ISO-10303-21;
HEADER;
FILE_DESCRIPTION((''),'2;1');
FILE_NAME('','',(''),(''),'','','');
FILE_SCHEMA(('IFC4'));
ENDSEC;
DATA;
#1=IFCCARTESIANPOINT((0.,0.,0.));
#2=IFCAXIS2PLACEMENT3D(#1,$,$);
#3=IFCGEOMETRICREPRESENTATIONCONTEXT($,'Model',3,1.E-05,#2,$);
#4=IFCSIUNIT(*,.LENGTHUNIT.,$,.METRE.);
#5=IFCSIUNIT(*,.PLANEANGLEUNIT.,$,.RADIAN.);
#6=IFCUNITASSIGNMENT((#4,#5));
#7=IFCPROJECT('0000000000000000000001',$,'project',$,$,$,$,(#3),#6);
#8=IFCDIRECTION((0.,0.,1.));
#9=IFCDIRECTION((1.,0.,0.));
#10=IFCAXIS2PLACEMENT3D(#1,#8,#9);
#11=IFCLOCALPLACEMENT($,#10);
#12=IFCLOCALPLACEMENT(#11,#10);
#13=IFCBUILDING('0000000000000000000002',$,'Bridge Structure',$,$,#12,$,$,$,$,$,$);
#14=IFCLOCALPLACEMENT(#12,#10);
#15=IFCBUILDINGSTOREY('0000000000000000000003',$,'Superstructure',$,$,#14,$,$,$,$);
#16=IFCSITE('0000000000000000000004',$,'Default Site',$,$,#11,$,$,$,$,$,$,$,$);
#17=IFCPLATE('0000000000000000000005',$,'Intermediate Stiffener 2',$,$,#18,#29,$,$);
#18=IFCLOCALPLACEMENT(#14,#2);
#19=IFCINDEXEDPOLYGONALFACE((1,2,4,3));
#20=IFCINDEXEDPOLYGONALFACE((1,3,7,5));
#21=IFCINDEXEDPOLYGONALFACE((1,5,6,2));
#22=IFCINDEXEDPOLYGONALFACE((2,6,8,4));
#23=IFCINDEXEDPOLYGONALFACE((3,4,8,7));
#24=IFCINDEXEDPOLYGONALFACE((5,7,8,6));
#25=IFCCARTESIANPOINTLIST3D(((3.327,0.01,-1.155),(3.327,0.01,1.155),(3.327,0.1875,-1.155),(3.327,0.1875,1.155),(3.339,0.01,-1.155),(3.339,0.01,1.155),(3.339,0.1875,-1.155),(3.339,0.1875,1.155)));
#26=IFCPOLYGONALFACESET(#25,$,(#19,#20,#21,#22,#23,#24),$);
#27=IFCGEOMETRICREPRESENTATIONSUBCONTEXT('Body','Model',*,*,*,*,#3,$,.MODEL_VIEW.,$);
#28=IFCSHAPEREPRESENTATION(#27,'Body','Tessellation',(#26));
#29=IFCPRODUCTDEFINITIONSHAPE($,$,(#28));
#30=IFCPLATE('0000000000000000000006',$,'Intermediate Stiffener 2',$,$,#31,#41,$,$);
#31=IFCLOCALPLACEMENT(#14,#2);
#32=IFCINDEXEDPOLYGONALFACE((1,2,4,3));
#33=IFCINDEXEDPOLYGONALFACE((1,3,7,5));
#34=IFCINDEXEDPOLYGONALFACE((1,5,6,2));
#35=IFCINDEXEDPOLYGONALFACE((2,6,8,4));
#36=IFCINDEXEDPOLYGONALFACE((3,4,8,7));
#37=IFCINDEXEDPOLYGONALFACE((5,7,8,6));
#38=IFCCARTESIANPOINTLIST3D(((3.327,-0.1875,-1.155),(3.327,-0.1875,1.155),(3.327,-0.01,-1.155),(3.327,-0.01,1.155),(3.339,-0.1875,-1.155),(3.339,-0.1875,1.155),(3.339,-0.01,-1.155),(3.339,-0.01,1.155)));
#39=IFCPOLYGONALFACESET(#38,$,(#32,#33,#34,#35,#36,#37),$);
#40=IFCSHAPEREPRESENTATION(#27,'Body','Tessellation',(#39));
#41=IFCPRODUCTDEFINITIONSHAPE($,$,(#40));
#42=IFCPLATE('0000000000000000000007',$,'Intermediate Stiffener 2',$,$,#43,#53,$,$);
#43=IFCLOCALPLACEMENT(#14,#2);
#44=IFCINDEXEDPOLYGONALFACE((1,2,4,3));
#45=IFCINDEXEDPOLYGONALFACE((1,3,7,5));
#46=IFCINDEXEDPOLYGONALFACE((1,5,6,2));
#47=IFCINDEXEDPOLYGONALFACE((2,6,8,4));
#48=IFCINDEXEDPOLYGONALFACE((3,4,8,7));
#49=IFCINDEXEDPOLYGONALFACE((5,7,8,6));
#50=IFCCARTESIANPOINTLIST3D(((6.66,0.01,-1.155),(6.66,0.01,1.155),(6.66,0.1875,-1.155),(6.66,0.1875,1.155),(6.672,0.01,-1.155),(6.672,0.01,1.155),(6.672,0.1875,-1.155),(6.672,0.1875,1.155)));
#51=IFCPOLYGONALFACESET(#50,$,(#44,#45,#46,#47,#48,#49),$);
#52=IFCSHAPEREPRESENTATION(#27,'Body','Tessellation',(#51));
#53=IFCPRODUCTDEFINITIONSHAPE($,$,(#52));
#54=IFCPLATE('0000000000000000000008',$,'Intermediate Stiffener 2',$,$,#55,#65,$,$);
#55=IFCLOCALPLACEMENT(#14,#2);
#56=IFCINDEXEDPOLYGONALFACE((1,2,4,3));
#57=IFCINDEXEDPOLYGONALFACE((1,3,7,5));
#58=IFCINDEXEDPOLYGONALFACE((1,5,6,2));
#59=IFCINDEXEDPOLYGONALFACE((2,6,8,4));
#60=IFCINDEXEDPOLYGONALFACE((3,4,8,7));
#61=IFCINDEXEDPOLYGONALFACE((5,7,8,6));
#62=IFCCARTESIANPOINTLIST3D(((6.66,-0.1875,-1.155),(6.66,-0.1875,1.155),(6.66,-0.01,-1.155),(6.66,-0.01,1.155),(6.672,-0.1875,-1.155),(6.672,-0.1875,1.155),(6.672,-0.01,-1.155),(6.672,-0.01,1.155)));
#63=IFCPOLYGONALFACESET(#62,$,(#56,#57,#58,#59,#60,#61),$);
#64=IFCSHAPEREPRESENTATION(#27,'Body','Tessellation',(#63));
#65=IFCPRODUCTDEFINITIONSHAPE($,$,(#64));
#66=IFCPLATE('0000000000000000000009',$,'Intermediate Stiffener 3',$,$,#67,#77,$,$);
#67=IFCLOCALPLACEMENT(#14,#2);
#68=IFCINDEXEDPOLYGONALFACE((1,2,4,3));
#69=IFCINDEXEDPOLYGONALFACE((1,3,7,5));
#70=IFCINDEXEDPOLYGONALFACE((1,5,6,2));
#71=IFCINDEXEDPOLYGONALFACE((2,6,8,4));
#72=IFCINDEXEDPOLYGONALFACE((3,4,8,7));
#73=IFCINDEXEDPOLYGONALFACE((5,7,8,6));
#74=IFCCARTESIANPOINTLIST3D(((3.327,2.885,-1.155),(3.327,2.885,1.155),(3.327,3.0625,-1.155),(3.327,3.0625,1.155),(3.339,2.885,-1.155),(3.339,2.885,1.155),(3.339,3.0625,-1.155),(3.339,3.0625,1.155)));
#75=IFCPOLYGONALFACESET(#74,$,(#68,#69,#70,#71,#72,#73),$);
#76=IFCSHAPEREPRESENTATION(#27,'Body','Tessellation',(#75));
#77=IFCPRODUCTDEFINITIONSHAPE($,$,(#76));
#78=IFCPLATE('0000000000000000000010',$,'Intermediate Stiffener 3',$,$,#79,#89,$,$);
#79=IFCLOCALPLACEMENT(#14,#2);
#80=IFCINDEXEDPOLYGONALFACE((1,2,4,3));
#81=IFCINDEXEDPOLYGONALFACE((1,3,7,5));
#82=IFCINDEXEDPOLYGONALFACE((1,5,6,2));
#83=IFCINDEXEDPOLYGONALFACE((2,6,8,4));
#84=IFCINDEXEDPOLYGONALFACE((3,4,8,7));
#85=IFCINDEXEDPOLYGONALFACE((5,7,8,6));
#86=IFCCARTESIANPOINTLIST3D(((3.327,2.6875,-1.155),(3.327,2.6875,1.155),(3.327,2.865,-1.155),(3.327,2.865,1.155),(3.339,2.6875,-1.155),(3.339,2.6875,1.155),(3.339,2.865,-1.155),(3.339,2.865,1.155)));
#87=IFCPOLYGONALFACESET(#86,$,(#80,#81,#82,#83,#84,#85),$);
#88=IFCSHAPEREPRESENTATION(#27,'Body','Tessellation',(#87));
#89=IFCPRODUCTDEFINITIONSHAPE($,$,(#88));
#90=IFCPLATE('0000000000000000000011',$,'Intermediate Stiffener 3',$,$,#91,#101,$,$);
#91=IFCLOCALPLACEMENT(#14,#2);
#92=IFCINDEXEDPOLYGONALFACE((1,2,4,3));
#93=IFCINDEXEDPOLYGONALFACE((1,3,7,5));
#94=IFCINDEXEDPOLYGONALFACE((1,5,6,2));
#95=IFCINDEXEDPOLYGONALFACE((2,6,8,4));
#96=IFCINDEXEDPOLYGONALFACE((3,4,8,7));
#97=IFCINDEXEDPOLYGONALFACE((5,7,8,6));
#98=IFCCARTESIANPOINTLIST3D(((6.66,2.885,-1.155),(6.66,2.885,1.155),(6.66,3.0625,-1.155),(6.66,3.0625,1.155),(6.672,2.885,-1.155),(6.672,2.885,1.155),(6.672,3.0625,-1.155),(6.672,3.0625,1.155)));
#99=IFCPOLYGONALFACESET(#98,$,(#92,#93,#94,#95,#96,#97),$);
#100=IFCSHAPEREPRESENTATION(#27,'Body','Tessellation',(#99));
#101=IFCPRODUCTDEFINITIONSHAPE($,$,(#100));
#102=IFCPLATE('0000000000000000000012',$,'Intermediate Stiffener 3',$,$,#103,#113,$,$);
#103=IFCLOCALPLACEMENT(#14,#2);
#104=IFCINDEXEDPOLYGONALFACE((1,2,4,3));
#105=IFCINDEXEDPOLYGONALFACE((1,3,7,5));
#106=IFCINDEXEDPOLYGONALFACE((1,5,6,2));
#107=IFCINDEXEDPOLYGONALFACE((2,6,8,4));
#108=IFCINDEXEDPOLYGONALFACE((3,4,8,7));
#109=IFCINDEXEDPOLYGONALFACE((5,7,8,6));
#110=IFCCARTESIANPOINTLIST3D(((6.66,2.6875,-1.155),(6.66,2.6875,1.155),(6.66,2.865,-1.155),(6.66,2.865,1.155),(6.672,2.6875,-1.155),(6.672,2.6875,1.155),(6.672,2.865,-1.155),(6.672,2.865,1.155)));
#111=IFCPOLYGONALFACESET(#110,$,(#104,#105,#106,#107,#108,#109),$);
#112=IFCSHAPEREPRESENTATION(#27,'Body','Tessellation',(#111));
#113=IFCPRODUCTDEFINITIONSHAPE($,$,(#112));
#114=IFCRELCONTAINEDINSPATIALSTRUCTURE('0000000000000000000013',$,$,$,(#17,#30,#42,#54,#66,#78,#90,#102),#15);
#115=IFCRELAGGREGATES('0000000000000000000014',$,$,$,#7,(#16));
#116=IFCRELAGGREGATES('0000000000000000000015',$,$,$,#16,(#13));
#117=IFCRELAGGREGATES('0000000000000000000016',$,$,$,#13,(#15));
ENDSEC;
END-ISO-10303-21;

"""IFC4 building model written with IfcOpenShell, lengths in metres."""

from ifc_helpers import new_model, si_unit, frame, origin, origin_with_axes, origin_2d_with_axis, place, context, subcontext, project, spatial, rectangle, extrude, element, save


model = new_model("IFC4")

# Units and contexts
model_context = context("Model", 3, precision=1e-05, world=origin())
body_context = subcontext(model_context, "Body", "Model", "MODEL_VIEW")
ifc_project = project(units=[si_unit("LENGTHUNIT", "METRE"), si_unit("PLANEANGLEUNIT", "RADIAN")], contexts=[model_context])

# Site, building, storey
site_placement = place(None, origin_with_axes())
site = spatial("IfcSite", under=ifc_project, at=site_placement, Name="Default Site")
building_placement = place(site_placement, origin_with_axes())
building = spatial("IfcBuilding", under=site, at=building_placement, Name="Bridge Structure")
storey_placement = place(building_placement, origin_with_axes())
storey = spatial("IfcBuildingStorey", under=building, at=storey_placement, Name="Superstructure")

# Plates
for number, where, z_axis, x_axis, name in (
    (1, (3.333, 0.0988, -1.155), (0.0, 0.0, 1.0), (1.0, 0.0, 0.0), "Intermediate Stiffener 2"),
    (2, (3.333, -0.0988, -1.155), (0.0, 0.0, 1.0), (1.0, 0.0, 0.0), "Intermediate Stiffener 2"),
    (3, (6.666, 0.0988, -1.155), (0.0, 0.0, 1.0), (1.0, 0.0, 0.0), "Intermediate Stiffener 2"),
    (4, (6.666, -0.0988, -1.155), (0.0, 0.0, 1.0), (1.0, 0.0, 0.0), "Intermediate Stiffener 2"),
    (5, (3.333, 2.9737, -1.155), (0.0, 0.0, 1.0), (1.0, 0.0, 0.0), "Intermediate Stiffener 3"),
    (6, (3.333, 2.7763, -1.155), (0.0, 0.0, 1.0), (1.0, 0.0, 0.0), "Intermediate Stiffener 3"),
    (7, (6.666, 2.9737, -1.155), (0.0, 0.0, 1.0), (1.0, 0.0, 0.0), "Intermediate Stiffener 3"),
    (8, (6.666, 2.7763, -1.155), (0.0, 0.0, 1.0), (1.0, 0.0, 0.0), "Intermediate Stiffener 3"),
):
    element("IfcPlate", number, at=place(storey_placement, frame(where, z_axis=z_axis, x_axis=x_axis)), inside=storey, Name=name, context=body_context, shape_type="SweptSolid", body=[
        extrude(rectangle(XDim=0.012, YDim=0.1775, at=origin_2d_with_axis()), origin_with_axes(), (0.0, 0.0, 1.0), 2.31),
    ])

save(model, "model.ifc")
